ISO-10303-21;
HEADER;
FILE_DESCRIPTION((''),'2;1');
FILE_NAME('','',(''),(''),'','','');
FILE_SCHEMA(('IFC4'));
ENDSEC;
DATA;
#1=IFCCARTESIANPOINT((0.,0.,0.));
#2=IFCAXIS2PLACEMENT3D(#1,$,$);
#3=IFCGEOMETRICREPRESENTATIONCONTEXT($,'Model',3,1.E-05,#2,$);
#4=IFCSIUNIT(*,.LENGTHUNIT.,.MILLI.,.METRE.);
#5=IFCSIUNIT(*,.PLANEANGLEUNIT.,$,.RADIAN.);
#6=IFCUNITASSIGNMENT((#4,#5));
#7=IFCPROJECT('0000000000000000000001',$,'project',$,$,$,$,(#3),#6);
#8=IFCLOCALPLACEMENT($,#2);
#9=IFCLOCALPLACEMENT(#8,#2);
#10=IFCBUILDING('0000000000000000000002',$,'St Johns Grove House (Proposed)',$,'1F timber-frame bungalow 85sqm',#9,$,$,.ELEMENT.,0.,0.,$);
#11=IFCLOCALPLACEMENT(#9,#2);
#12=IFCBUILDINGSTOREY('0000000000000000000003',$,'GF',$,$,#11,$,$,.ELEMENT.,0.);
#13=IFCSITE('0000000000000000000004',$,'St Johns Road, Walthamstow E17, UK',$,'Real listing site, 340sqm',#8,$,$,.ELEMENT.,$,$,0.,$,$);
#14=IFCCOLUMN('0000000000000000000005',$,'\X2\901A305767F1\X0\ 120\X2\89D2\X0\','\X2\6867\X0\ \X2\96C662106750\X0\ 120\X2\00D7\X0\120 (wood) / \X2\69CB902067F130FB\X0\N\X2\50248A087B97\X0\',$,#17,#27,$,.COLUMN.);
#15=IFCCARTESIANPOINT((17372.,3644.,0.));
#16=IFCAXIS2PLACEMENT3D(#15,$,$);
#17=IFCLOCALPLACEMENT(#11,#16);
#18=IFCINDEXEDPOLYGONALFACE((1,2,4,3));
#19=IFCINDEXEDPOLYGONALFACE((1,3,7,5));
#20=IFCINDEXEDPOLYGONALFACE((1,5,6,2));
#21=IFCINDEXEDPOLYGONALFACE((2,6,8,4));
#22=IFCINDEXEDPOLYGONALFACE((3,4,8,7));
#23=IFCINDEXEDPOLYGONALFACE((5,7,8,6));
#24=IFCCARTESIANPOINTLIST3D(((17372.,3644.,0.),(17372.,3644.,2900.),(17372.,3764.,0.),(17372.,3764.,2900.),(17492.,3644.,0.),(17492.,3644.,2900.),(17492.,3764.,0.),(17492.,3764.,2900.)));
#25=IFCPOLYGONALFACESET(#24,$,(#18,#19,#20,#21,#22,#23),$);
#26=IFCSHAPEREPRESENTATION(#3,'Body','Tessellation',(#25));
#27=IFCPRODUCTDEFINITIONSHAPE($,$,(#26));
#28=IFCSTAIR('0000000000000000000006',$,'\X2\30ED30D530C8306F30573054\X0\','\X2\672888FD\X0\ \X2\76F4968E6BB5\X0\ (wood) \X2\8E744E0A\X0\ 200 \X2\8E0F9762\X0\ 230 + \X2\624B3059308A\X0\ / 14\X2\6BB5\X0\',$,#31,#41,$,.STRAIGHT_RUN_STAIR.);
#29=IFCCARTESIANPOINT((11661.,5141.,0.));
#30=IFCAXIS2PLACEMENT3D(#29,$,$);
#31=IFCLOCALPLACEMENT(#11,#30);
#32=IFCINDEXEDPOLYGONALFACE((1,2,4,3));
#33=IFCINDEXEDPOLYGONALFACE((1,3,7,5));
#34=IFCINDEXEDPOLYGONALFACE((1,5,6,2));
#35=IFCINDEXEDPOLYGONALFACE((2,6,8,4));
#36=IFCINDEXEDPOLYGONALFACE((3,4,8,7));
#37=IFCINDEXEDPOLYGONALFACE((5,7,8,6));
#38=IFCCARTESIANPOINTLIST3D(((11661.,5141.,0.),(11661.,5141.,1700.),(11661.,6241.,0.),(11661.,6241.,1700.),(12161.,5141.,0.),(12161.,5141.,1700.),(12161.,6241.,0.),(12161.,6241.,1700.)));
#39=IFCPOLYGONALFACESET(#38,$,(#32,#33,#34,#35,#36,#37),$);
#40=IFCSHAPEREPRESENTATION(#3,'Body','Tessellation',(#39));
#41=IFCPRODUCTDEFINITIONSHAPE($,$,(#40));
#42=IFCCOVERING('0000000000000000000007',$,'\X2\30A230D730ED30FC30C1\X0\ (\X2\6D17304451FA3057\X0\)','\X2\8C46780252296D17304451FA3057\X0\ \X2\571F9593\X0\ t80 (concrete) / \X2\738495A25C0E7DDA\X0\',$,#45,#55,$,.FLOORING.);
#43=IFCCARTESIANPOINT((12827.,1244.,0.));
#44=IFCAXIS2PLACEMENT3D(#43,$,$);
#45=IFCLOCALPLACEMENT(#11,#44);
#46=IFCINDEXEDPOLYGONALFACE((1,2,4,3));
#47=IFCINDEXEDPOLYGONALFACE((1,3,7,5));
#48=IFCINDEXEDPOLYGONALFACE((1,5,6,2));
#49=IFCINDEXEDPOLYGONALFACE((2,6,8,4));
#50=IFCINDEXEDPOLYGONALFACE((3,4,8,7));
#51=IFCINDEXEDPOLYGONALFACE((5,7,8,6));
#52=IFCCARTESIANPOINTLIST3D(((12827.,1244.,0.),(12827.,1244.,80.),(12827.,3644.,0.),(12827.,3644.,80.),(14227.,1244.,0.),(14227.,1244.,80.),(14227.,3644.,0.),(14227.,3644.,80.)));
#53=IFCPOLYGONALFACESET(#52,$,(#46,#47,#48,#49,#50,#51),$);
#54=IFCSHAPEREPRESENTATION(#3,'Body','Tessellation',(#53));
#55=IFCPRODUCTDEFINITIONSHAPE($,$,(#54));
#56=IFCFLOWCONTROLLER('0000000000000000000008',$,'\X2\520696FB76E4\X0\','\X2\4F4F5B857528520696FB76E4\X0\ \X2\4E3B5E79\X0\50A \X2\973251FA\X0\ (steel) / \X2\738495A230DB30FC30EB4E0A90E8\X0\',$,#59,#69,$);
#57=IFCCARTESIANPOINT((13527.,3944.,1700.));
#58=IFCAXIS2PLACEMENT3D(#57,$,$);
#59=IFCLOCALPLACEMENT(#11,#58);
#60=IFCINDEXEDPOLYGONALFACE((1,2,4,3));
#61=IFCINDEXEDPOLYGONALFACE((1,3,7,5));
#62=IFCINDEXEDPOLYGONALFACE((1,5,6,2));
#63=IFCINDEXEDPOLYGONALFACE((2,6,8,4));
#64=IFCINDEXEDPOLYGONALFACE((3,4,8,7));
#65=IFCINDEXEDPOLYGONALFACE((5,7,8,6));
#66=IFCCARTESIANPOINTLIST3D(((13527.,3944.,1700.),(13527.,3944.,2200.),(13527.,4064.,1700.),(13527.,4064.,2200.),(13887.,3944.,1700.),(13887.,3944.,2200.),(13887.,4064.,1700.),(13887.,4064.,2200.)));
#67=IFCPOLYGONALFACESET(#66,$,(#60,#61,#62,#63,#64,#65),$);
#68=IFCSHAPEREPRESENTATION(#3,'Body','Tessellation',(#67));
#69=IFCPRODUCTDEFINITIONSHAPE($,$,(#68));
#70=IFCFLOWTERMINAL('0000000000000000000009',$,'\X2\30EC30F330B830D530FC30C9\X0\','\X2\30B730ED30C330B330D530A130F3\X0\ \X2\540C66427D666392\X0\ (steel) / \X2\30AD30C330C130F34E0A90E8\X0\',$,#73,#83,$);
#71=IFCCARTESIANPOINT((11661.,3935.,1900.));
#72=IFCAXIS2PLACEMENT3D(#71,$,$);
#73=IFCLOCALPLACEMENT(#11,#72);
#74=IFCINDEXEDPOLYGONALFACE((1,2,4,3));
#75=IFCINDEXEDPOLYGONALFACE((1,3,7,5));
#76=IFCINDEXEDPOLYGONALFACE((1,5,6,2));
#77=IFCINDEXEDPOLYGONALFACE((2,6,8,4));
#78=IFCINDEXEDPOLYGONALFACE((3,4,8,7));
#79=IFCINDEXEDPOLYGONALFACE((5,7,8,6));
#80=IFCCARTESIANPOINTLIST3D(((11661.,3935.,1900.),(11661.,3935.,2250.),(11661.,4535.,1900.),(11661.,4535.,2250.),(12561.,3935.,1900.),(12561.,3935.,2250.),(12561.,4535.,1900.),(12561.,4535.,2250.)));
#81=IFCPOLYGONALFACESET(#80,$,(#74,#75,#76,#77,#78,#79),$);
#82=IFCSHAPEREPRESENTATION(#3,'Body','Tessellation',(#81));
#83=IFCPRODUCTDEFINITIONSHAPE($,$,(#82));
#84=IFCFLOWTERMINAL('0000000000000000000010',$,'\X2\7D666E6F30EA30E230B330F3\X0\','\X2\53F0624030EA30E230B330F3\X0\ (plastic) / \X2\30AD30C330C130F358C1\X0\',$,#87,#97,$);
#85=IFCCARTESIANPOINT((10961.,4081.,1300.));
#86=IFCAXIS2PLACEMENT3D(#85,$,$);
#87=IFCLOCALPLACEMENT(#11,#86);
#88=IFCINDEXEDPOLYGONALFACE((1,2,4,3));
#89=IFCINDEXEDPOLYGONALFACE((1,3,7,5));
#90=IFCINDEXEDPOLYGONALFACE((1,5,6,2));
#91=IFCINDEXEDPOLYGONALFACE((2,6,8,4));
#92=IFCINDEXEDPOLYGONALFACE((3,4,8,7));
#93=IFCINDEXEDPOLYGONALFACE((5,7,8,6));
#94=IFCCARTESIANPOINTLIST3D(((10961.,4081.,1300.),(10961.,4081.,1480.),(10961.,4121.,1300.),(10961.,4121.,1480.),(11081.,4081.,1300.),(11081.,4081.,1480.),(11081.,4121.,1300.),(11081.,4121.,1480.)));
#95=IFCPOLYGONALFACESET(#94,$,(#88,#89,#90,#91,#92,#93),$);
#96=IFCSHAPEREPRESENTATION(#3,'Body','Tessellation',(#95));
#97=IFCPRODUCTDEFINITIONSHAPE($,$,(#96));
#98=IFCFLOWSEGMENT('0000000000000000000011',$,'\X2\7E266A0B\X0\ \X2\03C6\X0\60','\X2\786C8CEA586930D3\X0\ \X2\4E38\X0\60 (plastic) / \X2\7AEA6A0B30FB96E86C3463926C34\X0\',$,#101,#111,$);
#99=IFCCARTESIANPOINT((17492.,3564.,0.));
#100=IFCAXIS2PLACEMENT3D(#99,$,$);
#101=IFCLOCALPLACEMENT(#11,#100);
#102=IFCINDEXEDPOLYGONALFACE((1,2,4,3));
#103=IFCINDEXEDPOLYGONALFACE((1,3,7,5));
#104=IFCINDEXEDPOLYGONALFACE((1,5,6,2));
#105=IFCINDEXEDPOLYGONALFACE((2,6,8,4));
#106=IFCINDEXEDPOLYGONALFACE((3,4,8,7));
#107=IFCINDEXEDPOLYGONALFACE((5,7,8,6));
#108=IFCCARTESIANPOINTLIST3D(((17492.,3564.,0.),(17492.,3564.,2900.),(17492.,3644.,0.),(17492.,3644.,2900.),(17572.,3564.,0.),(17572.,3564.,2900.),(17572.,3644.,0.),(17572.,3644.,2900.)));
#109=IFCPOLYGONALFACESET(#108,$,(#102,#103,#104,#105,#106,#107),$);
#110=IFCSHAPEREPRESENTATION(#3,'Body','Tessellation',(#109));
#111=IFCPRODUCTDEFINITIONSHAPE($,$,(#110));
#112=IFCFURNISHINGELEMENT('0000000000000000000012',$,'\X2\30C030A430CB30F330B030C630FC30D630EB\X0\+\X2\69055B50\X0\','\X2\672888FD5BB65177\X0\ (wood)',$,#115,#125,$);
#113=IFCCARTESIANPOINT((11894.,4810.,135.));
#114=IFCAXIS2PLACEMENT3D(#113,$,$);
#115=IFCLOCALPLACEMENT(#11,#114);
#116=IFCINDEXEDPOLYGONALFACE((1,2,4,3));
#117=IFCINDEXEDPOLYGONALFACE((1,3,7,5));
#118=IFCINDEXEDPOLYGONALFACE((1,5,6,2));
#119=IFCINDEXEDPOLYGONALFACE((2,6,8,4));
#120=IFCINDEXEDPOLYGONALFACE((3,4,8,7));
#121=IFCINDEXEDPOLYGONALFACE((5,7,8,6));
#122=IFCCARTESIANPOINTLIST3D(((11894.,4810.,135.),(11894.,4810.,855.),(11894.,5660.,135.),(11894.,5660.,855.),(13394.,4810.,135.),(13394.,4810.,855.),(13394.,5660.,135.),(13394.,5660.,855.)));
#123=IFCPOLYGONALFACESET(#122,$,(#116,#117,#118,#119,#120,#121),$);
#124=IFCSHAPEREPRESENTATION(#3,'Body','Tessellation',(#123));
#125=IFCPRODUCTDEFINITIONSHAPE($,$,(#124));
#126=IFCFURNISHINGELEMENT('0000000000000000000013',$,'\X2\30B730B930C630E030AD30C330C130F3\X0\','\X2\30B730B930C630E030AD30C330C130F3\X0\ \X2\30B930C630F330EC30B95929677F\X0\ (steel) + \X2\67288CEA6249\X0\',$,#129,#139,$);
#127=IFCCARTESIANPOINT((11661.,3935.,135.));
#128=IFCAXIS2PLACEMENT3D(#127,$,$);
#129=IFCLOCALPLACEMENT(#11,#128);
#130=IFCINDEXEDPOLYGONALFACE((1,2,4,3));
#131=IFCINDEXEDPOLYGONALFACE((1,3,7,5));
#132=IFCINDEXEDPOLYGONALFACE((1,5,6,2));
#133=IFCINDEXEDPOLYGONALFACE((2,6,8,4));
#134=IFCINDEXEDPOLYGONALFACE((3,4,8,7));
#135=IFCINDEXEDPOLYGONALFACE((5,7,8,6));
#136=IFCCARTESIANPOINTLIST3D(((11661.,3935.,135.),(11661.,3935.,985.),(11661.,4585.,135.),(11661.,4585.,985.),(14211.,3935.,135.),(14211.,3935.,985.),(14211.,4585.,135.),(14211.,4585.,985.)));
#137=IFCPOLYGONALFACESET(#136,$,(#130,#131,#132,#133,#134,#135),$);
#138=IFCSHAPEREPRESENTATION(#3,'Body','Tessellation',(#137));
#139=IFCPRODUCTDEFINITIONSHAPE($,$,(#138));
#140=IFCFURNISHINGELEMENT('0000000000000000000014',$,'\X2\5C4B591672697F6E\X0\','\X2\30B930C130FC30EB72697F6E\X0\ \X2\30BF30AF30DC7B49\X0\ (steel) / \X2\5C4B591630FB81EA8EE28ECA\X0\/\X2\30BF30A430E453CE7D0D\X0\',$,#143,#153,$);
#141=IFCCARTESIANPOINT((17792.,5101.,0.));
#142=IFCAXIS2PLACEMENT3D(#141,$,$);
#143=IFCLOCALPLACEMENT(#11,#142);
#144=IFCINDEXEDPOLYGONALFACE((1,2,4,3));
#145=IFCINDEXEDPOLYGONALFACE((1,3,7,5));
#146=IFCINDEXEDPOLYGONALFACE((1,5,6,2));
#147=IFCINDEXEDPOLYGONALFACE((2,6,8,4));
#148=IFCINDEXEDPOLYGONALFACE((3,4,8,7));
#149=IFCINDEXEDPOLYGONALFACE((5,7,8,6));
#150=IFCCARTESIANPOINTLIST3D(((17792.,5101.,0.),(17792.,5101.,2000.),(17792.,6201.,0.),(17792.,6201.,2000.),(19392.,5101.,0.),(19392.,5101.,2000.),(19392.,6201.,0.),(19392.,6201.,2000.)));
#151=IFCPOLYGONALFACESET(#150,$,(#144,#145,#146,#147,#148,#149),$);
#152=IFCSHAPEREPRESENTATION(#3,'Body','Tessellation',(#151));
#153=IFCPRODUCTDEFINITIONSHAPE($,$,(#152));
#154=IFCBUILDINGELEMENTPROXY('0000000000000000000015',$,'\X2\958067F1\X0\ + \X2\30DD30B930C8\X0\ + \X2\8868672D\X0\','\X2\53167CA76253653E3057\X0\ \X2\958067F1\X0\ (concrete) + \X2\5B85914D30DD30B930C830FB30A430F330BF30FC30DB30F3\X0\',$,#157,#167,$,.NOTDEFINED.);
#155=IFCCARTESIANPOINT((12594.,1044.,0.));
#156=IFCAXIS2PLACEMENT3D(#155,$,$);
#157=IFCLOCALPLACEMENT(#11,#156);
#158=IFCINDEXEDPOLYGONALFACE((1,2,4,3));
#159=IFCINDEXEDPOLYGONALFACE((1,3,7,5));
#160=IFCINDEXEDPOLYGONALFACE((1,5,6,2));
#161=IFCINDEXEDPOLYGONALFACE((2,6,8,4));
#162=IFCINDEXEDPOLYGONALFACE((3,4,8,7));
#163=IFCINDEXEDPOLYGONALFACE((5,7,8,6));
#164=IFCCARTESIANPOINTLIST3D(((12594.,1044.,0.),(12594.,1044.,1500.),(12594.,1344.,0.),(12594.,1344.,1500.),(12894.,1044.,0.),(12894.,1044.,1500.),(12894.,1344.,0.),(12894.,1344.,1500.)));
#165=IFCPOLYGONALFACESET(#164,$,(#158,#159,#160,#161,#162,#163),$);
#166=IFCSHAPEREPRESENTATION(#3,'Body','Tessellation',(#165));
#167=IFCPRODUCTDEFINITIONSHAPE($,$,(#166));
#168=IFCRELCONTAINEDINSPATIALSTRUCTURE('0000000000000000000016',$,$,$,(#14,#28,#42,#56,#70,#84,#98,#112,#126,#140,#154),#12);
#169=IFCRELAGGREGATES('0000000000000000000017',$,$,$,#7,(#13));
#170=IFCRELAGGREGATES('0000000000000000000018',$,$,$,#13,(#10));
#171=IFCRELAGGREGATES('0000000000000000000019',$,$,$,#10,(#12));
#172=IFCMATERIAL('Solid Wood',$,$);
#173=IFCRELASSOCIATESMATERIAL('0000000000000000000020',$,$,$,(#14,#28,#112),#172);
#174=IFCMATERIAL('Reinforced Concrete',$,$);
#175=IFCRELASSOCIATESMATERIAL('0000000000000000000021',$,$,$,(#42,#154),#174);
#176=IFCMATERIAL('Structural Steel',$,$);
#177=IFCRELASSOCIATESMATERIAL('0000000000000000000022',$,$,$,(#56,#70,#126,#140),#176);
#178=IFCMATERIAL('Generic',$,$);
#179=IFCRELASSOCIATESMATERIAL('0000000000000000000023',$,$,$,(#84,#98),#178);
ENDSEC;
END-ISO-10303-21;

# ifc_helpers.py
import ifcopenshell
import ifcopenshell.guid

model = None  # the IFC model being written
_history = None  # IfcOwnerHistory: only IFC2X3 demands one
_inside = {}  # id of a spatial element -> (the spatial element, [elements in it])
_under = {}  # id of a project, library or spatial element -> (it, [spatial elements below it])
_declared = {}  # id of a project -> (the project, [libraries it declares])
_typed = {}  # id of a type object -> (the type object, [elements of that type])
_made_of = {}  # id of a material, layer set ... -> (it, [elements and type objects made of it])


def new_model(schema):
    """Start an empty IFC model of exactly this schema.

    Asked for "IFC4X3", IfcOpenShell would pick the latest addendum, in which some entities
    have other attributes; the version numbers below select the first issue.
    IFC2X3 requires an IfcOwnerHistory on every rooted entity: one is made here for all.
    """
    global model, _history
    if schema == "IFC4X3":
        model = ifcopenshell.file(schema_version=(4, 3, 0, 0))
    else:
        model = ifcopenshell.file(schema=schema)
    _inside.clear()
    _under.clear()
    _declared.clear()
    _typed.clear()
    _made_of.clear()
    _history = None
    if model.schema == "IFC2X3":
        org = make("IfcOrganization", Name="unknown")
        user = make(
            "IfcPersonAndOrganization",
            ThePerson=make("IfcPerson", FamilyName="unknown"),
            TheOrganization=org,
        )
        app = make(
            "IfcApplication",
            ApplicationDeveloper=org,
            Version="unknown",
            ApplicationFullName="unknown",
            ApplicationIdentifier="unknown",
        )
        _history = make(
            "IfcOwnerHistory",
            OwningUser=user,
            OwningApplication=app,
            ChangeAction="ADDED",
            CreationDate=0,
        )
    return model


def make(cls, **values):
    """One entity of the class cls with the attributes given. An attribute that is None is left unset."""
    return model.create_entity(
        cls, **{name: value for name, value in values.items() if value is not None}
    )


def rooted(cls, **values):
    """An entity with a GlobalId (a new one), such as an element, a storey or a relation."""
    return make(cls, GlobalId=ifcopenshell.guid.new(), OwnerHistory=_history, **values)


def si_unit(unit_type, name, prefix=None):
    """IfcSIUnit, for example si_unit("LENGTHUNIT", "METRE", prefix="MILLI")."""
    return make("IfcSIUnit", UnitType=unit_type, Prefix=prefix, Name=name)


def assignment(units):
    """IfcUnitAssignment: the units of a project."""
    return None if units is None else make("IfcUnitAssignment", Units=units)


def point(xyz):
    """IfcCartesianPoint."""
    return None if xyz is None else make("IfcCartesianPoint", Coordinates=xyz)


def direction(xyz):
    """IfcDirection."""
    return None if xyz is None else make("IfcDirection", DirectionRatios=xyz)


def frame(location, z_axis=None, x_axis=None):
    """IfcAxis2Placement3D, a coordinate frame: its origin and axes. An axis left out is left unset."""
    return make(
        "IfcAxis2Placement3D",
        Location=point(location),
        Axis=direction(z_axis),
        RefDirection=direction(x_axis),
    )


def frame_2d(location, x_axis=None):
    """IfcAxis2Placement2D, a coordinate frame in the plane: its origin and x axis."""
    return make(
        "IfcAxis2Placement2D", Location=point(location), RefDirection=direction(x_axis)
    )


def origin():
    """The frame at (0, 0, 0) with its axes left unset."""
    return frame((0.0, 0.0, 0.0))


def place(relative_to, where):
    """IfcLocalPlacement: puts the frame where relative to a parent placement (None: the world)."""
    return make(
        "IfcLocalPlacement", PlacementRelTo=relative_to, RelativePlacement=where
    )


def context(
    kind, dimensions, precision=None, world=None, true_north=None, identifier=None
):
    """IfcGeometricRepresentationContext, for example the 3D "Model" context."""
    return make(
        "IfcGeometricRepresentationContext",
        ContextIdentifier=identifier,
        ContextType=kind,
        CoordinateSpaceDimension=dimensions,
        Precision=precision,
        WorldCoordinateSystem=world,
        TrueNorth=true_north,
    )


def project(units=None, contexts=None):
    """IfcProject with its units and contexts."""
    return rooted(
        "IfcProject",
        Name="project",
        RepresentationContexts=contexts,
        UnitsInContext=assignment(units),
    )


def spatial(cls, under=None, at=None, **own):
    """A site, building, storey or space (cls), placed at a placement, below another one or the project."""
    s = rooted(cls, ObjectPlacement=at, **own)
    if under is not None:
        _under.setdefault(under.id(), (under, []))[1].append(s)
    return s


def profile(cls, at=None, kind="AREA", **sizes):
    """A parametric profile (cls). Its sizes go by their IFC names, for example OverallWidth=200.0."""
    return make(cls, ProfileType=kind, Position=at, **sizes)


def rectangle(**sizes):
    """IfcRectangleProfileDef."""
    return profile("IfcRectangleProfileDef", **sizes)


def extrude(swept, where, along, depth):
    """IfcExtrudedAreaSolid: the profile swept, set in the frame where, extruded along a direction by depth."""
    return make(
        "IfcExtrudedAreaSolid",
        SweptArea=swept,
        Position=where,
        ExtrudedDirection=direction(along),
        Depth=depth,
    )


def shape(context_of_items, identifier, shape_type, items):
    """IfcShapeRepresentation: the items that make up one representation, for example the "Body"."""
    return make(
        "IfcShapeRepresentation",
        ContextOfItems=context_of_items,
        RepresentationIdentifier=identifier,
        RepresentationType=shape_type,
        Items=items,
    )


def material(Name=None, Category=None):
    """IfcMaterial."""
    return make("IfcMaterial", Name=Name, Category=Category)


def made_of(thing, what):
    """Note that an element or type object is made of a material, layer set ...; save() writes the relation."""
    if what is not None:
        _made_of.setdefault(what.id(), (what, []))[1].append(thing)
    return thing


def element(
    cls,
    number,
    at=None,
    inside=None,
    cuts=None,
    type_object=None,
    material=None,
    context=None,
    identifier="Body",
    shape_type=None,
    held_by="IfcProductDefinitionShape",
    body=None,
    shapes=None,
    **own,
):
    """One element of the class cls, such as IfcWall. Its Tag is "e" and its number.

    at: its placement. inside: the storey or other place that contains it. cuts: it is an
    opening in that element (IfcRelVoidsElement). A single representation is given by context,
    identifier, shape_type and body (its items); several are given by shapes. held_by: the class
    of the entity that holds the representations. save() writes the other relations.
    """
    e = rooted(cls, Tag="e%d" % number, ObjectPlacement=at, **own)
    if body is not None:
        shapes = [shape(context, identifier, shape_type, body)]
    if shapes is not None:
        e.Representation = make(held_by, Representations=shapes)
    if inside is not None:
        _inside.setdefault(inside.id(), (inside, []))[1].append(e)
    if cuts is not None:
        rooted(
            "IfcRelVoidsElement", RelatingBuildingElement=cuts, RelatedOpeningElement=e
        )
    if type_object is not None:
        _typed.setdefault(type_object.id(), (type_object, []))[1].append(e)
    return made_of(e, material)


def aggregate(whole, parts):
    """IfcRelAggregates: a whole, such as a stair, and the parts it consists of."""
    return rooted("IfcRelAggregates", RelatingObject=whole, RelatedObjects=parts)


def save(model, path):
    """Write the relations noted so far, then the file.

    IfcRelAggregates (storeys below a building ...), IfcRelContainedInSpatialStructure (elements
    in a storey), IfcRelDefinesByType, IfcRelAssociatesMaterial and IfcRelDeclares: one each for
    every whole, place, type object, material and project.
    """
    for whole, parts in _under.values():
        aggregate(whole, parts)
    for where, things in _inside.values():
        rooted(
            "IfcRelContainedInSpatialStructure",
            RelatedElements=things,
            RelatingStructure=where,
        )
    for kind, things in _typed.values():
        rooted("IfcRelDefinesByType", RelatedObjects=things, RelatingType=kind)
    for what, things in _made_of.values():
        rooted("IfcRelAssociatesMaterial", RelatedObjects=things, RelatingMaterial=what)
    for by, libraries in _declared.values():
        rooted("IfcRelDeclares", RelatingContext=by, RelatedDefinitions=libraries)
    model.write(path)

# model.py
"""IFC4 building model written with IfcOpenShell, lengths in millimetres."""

from ifc_helpers import new_model, si_unit, frame, frame_2d, origin, place, context, project, spatial, rectangle, extrude, material, element, save


model = new_model("IFC4")

# Units and contexts
model_context = context("Model", 3, precision=1e-05, world=origin())
ifc_project = project(units=[si_unit("LENGTHUNIT", "METRE", prefix="MILLI"), si_unit("PLANEANGLEUNIT", "RADIAN")], contexts=[model_context])

# Site, building, storey
site_placement = place(None, origin())
site = spatial("IfcSite", under=ifc_project, at=site_placement, Name="St Johns Road, Walthamstow E17, UK", ObjectType="Real listing site, 340sqm", CompositionType="ELEMENT", RefElevation=0.0)
building_placement = place(site_placement, origin())
building = spatial("IfcBuilding", under=site, at=building_placement, Name="St Johns Grove House (Proposed)", ObjectType="1F timber-frame bungalow 85sqm", CompositionType="ELEMENT", ElevationOfRefHeight=0.0, ElevationOfTerrain=0.0)
storey_placement = place(building_placement, origin())
storey = spatial("IfcBuildingStorey", under=building, at=storey_placement, Name="GF", CompositionType="ELEMENT", Elevation=0.0)

# Column
ifc_material_1 = material(Name="Solid Wood")
column_1_placement = place(storey_placement, frame((17372.0, 3644.0, 0.0)))
element("IfcColumn", 1, at=column_1_placement, inside=storey, material=ifc_material_1, Name="通し柱 120角", Description="桧 集成材 120×120 (wood) / 構造柱・N値計算", PredefinedType="COLUMN", context=model_context, shape_type="SweptSolid", body=[
    extrude(rectangle(XDim=120.0, YDim=120.0, at=frame_2d((60.0, 60.0))), frame((17372.0, 3644.0, 0.0)), (0.0, 0.0, 1.0), 2900.0),
])

# Stair
stair_placement = place(storey_placement, frame((11661.0, 5141.0, 0.0)))
element("IfcStair", 2, at=stair_placement, inside=storey, material=ifc_material_1, Name="ロフトはしご", Description="木製 直階段 (wood) 蹴上 200 踏面 230 + 手すり / 14段", PredefinedType="STRAIGHT_RUN_STAIR", context=model_context, shape_type="SweptSolid", body=[
    extrude(rectangle(XDim=500.0, YDim=1100.0, at=frame_2d((250.0, 550.0))), frame((11661.0, 5141.0, 0.0)), (0.0, 0.0, 1.0), 1700.0),
])

# Covering
ifc_material_2 = material(Name="Reinforced Concrete")
covering_placement = place(storey_placement, frame((12827.0, 1244.0, 0.0)))
element("IfcCovering", 3, at=covering_placement, inside=storey, material=ifc_material_2, Name="アプローチ (洗い出し)", Description="豆砂利洗い出し 土間 t80 (concrete) / 玄関導線", PredefinedType="FLOORING", context=model_context, shape_type="SweptSolid", body=[
    extrude(rectangle(XDim=1400.0, YDim=2400.0, at=frame_2d((700.0, 1200.0))), frame((12827.0, 1244.0, 0.0)), (0.0, 0.0, 1.0), 80.0),
])

# Flow controller
ifc_material_3 = material(Name="Structural Steel")
flow_controller_placement = place(storey_placement, frame((13527.0, 3944.0, 1700.0)))
element("IfcFlowController", 4, at=flow_controller_placement, inside=storey, material=ifc_material_3, Name="分電盤", Description="住宅用分電盤 主幹50A 露出 (steel) / 玄関ホール上部", context=model_context, shape_type="SweptSolid", body=[
    extrude(rectangle(XDim=360.0, YDim=120.0, at=frame_2d((180.0, 60.0))), frame((13527.0, 3944.0, 1700.0)), (0.0, 0.0, 1.0), 500.0),
])

# Flow terminals
flow_terminal_1_placement = place(storey_placement, frame((11661.0, 3935.0, 1900.0)))
element("IfcFlowTerminal", 5, at=flow_terminal_1_placement, inside=storey, material=ifc_material_3, Name="レンジフード", Description="シロッコファン 同時給排 (steel) / キッチン上部", context=model_context, shape_type="SweptSolid", body=[
    extrude(rectangle(XDim=900.0, YDim=600.0, at=frame_2d((450.0, 300.0))), frame((11661.0, 3935.0, 1900.0)), (0.0, 0.0, 1.0), 350.0),
])
ifc_material_4 = material(Name="Generic")
flow_terminal_2_placement = place(storey_placement, frame((10961.0, 4081.0, 1300.0)))
element("IfcFlowTerminal", 6, at=flow_terminal_2_placement, inside=storey, material=ifc_material_4, Name="給湯リモコン", Description="台所リモコン (plastic) / キッチン壁", context=model_context, shape_type="SweptSolid", body=[
    extrude(rectangle(XDim=120.0, YDim=40.0, at=frame_2d((60.0, 20.0))), frame((10961.0, 4081.0, 1300.0)), (0.0, 0.0, 1.0), 180.0),
])

# Flow segment
flow_segment_placement = place(storey_placement, frame((17492.0, 3564.0, 0.0)))
element("IfcFlowSegment", 7, at=flow_segment_placement, inside=storey, material=ifc_material_4, Name="縦樋 φ60", Description="硬質塩ビ 丸60 (plastic) / 竪樋・雨水排水", context=model_context, shape_type="SweptSolid", body=[
    extrude(rectangle(XDim=80.0, YDim=80.0, at=frame_2d((40.0, 40.0))), frame((17492.0, 3564.0, 0.0)), (0.0, 0.0, 1.0), 2900.0),
])

# Furnishing elements
furnishing_1_placement = place(storey_placement, frame((11894.0, 4810.0, 135.0)))
element("IfcFurnishingElement", 8, at=furnishing_1_placement, inside=storey, material=ifc_material_1, Name="ダイニングテーブル+椅子", Description="木製家具 (wood)", context=model_context, shape_type="SweptSolid", body=[
    extrude(rectangle(XDim=1500.0, YDim=850.0, at=frame_2d((750.0, 425.0))), frame((11894.0, 4810.0, 135.0)), (0.0, 0.0, 1.0), 720.0),
])
furnishing_2_placement = place(storey_placement, frame((11661.0, 3935.0, 135.0)))
element("IfcFurnishingElement", 9, at=furnishing_2_placement, inside=storey, material=ifc_material_3, Name="システムキッチン", Description="システムキッチン ステンレス天板 (steel) + 木質扉", context=model_context, shape_type="SweptSolid", body=[
    extrude(rectangle(XDim=2550.0, YDim=650.0, at=frame_2d((1275.0, 325.0))), frame((11661.0, 3935.0, 135.0)), (0.0, 0.0, 1.0), 850.0),
])
furnishing_3_placement = place(storey_placement, frame((17792.0, 5101.0, 0.0)))
element("IfcFurnishingElement", 10, at=furnishing_3_placement, inside=storey, material=ifc_material_3, Name="屋外物置", Description="スチール物置 タクボ等 (steel) / 屋外・自転車/タイヤ収納", context=model_context, shape_type="SweptSolid", body=[
    extrude(rectangle(XDim=1600.0, YDim=1100.0, at=frame_2d((800.0, 550.0))), frame((17792.0, 5101.0, 0.0)), (0.0, 0.0, 1.0), 2000.0),
])

# Building element proxy
proxy_placement = place(storey_placement, frame((12594.0, 1044.0, 0.0)))
element("IfcBuildingElementProxy", 11, at=proxy_placement, inside=storey, material=ifc_material_2, Name="門柱 + ポスト + 表札", Description="化粧打放し 門柱 (concrete) + 宅配ポスト・インターホン", PredefinedType="NOTDEFINED", context=model_context, shape_type="SweptSolid", body=[
    extrude(rectangle(XDim=300.0, YDim=300.0, at=frame_2d((150.0, 150.0))), frame((12594.0, 1044.0, 0.0)), (0.0, 0.0, 1.0), 1500.0),
])

save(model, "model.ifc")
